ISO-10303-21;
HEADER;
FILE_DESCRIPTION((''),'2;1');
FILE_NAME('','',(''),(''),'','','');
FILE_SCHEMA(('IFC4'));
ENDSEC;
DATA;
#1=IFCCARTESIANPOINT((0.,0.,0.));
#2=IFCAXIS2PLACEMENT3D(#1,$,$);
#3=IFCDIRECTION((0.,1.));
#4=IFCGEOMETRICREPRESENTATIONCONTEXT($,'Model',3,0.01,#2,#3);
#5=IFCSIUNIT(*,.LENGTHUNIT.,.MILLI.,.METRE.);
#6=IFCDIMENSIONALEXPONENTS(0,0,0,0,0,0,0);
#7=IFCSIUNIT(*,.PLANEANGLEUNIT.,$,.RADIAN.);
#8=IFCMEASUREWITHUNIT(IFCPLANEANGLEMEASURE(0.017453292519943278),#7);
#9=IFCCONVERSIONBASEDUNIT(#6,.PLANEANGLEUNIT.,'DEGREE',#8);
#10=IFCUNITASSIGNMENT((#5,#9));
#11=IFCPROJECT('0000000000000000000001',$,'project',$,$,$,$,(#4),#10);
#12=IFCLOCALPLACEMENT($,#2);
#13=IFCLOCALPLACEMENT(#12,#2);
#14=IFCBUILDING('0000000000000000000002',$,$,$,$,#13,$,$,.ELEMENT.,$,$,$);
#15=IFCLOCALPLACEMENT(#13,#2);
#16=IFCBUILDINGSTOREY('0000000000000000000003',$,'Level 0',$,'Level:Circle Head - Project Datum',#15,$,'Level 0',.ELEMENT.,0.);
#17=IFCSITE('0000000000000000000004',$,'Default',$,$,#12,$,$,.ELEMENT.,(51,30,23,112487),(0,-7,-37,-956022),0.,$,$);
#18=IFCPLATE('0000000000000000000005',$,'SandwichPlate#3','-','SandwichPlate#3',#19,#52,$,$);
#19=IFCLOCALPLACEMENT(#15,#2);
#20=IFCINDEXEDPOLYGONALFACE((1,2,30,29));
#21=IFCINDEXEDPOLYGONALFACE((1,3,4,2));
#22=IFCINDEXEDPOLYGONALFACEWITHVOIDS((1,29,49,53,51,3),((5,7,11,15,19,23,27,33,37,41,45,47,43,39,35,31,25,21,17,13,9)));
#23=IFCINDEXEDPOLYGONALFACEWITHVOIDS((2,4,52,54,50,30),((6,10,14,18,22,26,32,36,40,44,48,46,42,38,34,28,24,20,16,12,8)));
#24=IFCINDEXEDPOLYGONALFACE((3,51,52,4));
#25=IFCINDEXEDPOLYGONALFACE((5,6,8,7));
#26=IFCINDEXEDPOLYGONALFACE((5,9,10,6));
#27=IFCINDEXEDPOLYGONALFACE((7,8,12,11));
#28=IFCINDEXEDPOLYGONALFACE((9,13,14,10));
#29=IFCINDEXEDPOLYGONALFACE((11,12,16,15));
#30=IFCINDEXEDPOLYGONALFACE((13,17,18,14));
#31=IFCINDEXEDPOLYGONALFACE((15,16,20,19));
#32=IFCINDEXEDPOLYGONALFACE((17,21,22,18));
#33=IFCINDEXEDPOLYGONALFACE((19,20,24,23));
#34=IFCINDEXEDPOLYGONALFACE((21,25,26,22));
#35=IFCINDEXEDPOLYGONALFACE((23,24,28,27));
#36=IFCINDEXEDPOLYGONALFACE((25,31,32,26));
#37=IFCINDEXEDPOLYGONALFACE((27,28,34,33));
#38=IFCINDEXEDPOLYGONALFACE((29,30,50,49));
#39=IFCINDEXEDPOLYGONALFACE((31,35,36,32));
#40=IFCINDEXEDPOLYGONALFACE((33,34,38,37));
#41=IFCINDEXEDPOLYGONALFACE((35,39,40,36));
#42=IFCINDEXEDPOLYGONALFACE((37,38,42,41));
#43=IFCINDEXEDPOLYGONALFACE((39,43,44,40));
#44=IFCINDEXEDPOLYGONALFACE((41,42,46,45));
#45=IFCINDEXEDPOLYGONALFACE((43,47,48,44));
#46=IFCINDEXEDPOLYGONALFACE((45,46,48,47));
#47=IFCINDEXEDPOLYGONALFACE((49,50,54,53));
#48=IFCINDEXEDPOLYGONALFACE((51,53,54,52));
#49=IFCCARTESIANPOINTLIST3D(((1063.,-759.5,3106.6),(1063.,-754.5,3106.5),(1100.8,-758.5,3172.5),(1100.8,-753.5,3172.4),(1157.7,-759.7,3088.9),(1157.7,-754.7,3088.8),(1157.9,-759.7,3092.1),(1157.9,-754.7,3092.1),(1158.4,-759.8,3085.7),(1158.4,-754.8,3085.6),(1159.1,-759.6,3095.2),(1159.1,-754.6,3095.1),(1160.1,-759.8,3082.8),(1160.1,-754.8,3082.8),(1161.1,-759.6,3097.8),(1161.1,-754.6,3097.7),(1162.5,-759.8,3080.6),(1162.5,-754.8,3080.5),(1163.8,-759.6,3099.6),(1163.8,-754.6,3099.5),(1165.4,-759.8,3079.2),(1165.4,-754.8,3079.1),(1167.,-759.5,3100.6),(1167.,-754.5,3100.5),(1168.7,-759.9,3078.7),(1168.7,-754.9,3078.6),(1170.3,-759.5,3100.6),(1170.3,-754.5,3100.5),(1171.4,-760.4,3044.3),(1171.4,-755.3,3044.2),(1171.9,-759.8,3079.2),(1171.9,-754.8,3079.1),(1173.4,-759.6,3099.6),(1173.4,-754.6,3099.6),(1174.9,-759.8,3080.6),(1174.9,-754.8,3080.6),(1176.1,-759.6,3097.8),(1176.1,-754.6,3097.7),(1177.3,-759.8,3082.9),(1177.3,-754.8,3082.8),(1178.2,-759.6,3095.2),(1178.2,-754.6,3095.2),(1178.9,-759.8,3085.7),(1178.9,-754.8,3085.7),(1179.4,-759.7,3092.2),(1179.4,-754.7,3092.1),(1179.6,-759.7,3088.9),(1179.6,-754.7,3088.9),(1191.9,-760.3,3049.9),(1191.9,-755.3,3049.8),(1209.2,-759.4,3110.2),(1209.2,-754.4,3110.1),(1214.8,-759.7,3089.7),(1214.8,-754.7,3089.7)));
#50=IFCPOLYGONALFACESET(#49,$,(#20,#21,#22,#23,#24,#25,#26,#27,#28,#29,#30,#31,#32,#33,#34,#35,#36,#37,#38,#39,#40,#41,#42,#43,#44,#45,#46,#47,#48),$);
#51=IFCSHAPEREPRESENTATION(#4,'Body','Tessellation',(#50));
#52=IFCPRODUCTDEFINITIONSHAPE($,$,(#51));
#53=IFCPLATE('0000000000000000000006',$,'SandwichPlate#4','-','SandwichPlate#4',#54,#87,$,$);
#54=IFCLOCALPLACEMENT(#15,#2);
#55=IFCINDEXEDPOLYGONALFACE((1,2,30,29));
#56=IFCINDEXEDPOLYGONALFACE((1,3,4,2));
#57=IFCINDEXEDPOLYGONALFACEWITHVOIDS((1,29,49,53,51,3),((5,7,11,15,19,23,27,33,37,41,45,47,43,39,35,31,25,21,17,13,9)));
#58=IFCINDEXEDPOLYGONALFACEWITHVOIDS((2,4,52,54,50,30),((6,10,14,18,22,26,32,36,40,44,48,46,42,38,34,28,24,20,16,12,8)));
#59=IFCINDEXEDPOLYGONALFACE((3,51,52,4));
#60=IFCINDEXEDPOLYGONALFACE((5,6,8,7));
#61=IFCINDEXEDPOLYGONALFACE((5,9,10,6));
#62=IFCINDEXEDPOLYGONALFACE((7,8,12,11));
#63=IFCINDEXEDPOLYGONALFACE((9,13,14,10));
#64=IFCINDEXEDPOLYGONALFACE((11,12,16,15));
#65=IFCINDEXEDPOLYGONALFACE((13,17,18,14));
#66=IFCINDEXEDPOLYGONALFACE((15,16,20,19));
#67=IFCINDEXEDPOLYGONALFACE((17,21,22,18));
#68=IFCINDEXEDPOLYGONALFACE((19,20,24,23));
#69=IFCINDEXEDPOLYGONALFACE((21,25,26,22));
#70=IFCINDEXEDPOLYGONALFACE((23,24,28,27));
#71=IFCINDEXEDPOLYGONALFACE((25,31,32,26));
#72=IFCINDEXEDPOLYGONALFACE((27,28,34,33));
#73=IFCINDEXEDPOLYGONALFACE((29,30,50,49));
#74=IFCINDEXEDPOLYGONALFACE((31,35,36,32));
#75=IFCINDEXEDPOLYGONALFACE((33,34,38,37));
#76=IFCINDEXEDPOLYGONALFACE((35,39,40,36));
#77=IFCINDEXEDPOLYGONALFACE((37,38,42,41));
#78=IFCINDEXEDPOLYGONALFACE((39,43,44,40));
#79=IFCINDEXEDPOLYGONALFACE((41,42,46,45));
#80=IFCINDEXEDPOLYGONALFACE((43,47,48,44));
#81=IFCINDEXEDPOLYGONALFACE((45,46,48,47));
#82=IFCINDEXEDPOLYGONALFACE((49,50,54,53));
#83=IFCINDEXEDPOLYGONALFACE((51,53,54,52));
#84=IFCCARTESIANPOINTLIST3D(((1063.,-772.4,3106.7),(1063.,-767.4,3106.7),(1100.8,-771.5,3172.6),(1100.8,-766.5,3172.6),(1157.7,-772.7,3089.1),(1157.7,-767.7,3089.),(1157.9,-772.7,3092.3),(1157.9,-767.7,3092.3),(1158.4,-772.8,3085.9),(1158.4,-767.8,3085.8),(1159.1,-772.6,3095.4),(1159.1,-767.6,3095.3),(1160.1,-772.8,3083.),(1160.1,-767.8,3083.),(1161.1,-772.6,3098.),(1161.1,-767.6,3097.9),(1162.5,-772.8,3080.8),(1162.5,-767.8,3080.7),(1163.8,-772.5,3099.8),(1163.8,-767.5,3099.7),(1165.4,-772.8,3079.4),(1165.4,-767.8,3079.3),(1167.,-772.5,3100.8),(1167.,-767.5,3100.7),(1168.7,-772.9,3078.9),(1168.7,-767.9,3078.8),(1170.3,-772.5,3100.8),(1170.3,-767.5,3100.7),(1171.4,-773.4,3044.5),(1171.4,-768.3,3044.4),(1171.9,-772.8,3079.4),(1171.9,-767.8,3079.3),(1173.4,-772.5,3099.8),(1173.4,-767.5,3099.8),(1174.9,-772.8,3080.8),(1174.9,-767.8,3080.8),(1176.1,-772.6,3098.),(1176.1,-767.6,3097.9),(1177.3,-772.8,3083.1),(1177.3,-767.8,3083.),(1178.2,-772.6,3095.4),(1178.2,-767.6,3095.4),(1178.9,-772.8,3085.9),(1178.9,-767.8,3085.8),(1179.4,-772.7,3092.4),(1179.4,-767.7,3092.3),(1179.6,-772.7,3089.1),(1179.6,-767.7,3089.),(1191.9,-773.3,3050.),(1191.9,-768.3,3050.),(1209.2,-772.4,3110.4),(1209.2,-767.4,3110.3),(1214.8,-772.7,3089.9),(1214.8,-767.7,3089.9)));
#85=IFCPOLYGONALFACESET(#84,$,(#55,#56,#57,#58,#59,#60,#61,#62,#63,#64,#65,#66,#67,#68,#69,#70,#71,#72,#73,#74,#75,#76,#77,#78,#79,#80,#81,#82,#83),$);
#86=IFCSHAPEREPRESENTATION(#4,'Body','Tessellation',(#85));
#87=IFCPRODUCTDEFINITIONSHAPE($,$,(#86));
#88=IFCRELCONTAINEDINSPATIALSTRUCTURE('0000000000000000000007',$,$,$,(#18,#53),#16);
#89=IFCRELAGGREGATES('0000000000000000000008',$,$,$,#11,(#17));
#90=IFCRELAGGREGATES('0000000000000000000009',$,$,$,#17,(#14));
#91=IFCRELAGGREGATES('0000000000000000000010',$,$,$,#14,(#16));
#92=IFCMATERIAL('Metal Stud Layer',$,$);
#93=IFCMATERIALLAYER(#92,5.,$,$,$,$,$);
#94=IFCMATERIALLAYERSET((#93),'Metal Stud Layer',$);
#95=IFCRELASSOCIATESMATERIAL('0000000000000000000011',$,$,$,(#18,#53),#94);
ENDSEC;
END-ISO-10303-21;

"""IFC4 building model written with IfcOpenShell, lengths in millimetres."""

from ifc_helpers import new_model, entity, si_unit, converted_unit, direction, frame, origin, origin_with_axes, origin_2d_with_axis, place, context, project, spatial, polyline, circle, outline, extrude, material, layer, layer_set, element, save


model = new_model("IFC4")

# Units and contexts
model_context = context("Model", 3, precision=0.01, world=origin(), true_north=direction((0.0, 1.0)))
ifc_project = project(units=[si_unit("LENGTHUNIT", "METRE", prefix="MILLI"), converted_unit("PLANEANGLEUNIT", "DEGREE", entity("IfcPlaneAngleMeasure", 0.017453292519943278), si_unit("PLANEANGLEUNIT", "RADIAN"), dimensions=[0, 0, 0, 0, 0, 0, 0])], contexts=[model_context])

# Site, building, storey
site_placement = place(None, origin())
site = spatial("IfcSite", under=ifc_project, at=site_placement, Name="Default", CompositionType="ELEMENT", RefLatitude=(51, 30, 23, 112487), RefLongitude=(0, -7, -37, -956022), RefElevation=0.0)
building_placement = place(site_placement, origin())
building = spatial("IfcBuilding", under=site, at=building_placement, CompositionType="ELEMENT")
storey_placement = place(building_placement, origin())
storey = spatial("IfcBuildingStorey", under=building, at=storey_placement, Name="Level 0", ObjectType="Level:Circle Head - Project Datum", LongName="Level 0", CompositionType="ELEMENT", Elevation=0.0)

# Plates, openings
ifc_material = material(Name="Metal Stud Layer")
ifc_layer_1 = layer(ifc_material, 5.0)
ifc_layer_set_1 = layer_set([ifc_layer_1], Name="Metal Stud Layer")
plate_1_placement = place(storey_placement, frame((1184.4, -755.5, 3036.8), z_axis=(0.0, -0.999896, 0.014432), x_axis=(0.497964, 0.012516, 0.867107)))
plate_1 = element("IfcPlate", 1, at=plate_1_placement, inside=storey, material=ifc_layer_set_1, Name="SandwichPlate#3", Description="-", ObjectType="SandwichPlate#3", context=model_context, shape_type="SweptSolid", body=[
    extrude(outline(polyline([(0.0, 0.0), (76.0, 0.0), (76.0, 140.0), (0.0, 140.0), (0.0, 0.0)])), origin_with_axes(), (0.0, 0.0, 1.0), 5.0),
])
opening_1_placement = place(plate_1_placement, frame((0.0, 0.0, 0.0), z_axis=(0.0, 0.0, 1.0), x_axis=(1.0, 0.0, 0.0)))
element("IfcOpeningElement", 2, at=opening_1_placement, cuts=plate_1, ObjectType="Opening", context=model_context, shape_type="SweptSolid", body=[
    extrude(outline(polyline([(0.0, 0.0), (15.0, 0.0), (0.0, 15.0), (0.0, 0.0)])), origin(), (0.0, 0.0, 1.0), 5.0),
])
opening_2_placement = place(plate_1_placement, frame((0.0, 0.0, 0.0), z_axis=(0.0, 0.0, 1.0), x_axis=(1.0, 0.0, 0.0)))
element("IfcOpeningElement", 3, at=opening_2_placement, cuts=plate_1, ObjectType="Opening", context=model_context, shape_type="SweptSolid", body=[
    extrude(outline(polyline([(76.0, 0.0), (76.0, 15.0), (61.0, 0.0), (76.0, 0.0)])), origin(), (0.0, 0.0, 1.0), 5.0),
])
opening_3_placement = place(plate_1_placement, frame((38.0, 40.0, -0.5), z_axis=(0.0, 0.0, 1.0), x_axis=(0.0, 1.0, 0.0)))
element("IfcOpeningElement", 4, at=opening_3_placement, cuts=plate_1, ObjectType="Opening", context=model_context, shape_type="SweptSolid", body=[
    extrude(circle(Radius=11.0, at=origin_2d_with_axis()), origin(), (0.0, 0.0, 1.0), 6.0),
])
plate_2_placement = place(storey_placement, frame((1184.4, -768.5, 3037.0), z_axis=(0.0, -0.999896, 0.014432), x_axis=(0.497964, 0.012516, 0.867107)))
plate_2 = element("IfcPlate", 5, at=plate_2_placement, inside=storey, material=ifc_layer_set_1, Name="SandwichPlate#4", Description="-", ObjectType="SandwichPlate#4", context=model_context, shape_type="SweptSolid", body=[
    extrude(outline(polyline([(0.0, 0.0), (76.0, 0.0), (76.0, 140.0), (0.0, 140.0), (0.0, 0.0)])), origin_with_axes(), (0.0, 0.0, 1.0), 5.0),
])
opening_4_placement = place(plate_2_placement, frame((0.0, 0.0, 0.0), z_axis=(0.0, 0.0, 1.0), x_axis=(1.0, 0.0, 0.0)))
element("IfcOpeningElement", 6, at=opening_4_placement, cuts=plate_2, ObjectType="Opening", context=model_context, shape_type="SweptSolid", body=[
    extrude(outline(polyline([(0.0, 0.0), (15.0, 0.0), (0.0, 15.0), (0.0, 0.0)])), origin(), (0.0, 0.0, 1.0), 5.0),
])
opening_5_placement = place(plate_2_placement, frame((0.0, 0.0, 0.0), z_axis=(0.0, 0.0, 1.0), x_axis=(1.0, 0.0, 0.0)))
element("IfcOpeningElement", 7, at=opening_5_placement, cuts=plate_2, ObjectType="Opening", context=model_context, shape_type="SweptSolid", body=[
    extrude(outline(polyline([(76.0, 0.0), (76.0, 15.0), (61.0, 0.0), (76.0, 0.0)])), origin(), (0.0, 0.0, 1.0), 5.0),
])
opening_6_placement = place(plate_2_placement, frame((38.0, 40.0, -0.5), z_axis=(0.0, 0.0, 1.0), x_axis=(0.0, 1.0, 0.0)))
element("IfcOpeningElement", 8, at=opening_6_placement, cuts=plate_2, ObjectType="Opening", context=model_context, shape_type="SweptSolid", body=[
    extrude(circle(Radius=11.0, at=origin_2d_with_axis()), origin(), (0.0, 0.0, 1.0), 6.0),
])

save(model, "model.ifc")
